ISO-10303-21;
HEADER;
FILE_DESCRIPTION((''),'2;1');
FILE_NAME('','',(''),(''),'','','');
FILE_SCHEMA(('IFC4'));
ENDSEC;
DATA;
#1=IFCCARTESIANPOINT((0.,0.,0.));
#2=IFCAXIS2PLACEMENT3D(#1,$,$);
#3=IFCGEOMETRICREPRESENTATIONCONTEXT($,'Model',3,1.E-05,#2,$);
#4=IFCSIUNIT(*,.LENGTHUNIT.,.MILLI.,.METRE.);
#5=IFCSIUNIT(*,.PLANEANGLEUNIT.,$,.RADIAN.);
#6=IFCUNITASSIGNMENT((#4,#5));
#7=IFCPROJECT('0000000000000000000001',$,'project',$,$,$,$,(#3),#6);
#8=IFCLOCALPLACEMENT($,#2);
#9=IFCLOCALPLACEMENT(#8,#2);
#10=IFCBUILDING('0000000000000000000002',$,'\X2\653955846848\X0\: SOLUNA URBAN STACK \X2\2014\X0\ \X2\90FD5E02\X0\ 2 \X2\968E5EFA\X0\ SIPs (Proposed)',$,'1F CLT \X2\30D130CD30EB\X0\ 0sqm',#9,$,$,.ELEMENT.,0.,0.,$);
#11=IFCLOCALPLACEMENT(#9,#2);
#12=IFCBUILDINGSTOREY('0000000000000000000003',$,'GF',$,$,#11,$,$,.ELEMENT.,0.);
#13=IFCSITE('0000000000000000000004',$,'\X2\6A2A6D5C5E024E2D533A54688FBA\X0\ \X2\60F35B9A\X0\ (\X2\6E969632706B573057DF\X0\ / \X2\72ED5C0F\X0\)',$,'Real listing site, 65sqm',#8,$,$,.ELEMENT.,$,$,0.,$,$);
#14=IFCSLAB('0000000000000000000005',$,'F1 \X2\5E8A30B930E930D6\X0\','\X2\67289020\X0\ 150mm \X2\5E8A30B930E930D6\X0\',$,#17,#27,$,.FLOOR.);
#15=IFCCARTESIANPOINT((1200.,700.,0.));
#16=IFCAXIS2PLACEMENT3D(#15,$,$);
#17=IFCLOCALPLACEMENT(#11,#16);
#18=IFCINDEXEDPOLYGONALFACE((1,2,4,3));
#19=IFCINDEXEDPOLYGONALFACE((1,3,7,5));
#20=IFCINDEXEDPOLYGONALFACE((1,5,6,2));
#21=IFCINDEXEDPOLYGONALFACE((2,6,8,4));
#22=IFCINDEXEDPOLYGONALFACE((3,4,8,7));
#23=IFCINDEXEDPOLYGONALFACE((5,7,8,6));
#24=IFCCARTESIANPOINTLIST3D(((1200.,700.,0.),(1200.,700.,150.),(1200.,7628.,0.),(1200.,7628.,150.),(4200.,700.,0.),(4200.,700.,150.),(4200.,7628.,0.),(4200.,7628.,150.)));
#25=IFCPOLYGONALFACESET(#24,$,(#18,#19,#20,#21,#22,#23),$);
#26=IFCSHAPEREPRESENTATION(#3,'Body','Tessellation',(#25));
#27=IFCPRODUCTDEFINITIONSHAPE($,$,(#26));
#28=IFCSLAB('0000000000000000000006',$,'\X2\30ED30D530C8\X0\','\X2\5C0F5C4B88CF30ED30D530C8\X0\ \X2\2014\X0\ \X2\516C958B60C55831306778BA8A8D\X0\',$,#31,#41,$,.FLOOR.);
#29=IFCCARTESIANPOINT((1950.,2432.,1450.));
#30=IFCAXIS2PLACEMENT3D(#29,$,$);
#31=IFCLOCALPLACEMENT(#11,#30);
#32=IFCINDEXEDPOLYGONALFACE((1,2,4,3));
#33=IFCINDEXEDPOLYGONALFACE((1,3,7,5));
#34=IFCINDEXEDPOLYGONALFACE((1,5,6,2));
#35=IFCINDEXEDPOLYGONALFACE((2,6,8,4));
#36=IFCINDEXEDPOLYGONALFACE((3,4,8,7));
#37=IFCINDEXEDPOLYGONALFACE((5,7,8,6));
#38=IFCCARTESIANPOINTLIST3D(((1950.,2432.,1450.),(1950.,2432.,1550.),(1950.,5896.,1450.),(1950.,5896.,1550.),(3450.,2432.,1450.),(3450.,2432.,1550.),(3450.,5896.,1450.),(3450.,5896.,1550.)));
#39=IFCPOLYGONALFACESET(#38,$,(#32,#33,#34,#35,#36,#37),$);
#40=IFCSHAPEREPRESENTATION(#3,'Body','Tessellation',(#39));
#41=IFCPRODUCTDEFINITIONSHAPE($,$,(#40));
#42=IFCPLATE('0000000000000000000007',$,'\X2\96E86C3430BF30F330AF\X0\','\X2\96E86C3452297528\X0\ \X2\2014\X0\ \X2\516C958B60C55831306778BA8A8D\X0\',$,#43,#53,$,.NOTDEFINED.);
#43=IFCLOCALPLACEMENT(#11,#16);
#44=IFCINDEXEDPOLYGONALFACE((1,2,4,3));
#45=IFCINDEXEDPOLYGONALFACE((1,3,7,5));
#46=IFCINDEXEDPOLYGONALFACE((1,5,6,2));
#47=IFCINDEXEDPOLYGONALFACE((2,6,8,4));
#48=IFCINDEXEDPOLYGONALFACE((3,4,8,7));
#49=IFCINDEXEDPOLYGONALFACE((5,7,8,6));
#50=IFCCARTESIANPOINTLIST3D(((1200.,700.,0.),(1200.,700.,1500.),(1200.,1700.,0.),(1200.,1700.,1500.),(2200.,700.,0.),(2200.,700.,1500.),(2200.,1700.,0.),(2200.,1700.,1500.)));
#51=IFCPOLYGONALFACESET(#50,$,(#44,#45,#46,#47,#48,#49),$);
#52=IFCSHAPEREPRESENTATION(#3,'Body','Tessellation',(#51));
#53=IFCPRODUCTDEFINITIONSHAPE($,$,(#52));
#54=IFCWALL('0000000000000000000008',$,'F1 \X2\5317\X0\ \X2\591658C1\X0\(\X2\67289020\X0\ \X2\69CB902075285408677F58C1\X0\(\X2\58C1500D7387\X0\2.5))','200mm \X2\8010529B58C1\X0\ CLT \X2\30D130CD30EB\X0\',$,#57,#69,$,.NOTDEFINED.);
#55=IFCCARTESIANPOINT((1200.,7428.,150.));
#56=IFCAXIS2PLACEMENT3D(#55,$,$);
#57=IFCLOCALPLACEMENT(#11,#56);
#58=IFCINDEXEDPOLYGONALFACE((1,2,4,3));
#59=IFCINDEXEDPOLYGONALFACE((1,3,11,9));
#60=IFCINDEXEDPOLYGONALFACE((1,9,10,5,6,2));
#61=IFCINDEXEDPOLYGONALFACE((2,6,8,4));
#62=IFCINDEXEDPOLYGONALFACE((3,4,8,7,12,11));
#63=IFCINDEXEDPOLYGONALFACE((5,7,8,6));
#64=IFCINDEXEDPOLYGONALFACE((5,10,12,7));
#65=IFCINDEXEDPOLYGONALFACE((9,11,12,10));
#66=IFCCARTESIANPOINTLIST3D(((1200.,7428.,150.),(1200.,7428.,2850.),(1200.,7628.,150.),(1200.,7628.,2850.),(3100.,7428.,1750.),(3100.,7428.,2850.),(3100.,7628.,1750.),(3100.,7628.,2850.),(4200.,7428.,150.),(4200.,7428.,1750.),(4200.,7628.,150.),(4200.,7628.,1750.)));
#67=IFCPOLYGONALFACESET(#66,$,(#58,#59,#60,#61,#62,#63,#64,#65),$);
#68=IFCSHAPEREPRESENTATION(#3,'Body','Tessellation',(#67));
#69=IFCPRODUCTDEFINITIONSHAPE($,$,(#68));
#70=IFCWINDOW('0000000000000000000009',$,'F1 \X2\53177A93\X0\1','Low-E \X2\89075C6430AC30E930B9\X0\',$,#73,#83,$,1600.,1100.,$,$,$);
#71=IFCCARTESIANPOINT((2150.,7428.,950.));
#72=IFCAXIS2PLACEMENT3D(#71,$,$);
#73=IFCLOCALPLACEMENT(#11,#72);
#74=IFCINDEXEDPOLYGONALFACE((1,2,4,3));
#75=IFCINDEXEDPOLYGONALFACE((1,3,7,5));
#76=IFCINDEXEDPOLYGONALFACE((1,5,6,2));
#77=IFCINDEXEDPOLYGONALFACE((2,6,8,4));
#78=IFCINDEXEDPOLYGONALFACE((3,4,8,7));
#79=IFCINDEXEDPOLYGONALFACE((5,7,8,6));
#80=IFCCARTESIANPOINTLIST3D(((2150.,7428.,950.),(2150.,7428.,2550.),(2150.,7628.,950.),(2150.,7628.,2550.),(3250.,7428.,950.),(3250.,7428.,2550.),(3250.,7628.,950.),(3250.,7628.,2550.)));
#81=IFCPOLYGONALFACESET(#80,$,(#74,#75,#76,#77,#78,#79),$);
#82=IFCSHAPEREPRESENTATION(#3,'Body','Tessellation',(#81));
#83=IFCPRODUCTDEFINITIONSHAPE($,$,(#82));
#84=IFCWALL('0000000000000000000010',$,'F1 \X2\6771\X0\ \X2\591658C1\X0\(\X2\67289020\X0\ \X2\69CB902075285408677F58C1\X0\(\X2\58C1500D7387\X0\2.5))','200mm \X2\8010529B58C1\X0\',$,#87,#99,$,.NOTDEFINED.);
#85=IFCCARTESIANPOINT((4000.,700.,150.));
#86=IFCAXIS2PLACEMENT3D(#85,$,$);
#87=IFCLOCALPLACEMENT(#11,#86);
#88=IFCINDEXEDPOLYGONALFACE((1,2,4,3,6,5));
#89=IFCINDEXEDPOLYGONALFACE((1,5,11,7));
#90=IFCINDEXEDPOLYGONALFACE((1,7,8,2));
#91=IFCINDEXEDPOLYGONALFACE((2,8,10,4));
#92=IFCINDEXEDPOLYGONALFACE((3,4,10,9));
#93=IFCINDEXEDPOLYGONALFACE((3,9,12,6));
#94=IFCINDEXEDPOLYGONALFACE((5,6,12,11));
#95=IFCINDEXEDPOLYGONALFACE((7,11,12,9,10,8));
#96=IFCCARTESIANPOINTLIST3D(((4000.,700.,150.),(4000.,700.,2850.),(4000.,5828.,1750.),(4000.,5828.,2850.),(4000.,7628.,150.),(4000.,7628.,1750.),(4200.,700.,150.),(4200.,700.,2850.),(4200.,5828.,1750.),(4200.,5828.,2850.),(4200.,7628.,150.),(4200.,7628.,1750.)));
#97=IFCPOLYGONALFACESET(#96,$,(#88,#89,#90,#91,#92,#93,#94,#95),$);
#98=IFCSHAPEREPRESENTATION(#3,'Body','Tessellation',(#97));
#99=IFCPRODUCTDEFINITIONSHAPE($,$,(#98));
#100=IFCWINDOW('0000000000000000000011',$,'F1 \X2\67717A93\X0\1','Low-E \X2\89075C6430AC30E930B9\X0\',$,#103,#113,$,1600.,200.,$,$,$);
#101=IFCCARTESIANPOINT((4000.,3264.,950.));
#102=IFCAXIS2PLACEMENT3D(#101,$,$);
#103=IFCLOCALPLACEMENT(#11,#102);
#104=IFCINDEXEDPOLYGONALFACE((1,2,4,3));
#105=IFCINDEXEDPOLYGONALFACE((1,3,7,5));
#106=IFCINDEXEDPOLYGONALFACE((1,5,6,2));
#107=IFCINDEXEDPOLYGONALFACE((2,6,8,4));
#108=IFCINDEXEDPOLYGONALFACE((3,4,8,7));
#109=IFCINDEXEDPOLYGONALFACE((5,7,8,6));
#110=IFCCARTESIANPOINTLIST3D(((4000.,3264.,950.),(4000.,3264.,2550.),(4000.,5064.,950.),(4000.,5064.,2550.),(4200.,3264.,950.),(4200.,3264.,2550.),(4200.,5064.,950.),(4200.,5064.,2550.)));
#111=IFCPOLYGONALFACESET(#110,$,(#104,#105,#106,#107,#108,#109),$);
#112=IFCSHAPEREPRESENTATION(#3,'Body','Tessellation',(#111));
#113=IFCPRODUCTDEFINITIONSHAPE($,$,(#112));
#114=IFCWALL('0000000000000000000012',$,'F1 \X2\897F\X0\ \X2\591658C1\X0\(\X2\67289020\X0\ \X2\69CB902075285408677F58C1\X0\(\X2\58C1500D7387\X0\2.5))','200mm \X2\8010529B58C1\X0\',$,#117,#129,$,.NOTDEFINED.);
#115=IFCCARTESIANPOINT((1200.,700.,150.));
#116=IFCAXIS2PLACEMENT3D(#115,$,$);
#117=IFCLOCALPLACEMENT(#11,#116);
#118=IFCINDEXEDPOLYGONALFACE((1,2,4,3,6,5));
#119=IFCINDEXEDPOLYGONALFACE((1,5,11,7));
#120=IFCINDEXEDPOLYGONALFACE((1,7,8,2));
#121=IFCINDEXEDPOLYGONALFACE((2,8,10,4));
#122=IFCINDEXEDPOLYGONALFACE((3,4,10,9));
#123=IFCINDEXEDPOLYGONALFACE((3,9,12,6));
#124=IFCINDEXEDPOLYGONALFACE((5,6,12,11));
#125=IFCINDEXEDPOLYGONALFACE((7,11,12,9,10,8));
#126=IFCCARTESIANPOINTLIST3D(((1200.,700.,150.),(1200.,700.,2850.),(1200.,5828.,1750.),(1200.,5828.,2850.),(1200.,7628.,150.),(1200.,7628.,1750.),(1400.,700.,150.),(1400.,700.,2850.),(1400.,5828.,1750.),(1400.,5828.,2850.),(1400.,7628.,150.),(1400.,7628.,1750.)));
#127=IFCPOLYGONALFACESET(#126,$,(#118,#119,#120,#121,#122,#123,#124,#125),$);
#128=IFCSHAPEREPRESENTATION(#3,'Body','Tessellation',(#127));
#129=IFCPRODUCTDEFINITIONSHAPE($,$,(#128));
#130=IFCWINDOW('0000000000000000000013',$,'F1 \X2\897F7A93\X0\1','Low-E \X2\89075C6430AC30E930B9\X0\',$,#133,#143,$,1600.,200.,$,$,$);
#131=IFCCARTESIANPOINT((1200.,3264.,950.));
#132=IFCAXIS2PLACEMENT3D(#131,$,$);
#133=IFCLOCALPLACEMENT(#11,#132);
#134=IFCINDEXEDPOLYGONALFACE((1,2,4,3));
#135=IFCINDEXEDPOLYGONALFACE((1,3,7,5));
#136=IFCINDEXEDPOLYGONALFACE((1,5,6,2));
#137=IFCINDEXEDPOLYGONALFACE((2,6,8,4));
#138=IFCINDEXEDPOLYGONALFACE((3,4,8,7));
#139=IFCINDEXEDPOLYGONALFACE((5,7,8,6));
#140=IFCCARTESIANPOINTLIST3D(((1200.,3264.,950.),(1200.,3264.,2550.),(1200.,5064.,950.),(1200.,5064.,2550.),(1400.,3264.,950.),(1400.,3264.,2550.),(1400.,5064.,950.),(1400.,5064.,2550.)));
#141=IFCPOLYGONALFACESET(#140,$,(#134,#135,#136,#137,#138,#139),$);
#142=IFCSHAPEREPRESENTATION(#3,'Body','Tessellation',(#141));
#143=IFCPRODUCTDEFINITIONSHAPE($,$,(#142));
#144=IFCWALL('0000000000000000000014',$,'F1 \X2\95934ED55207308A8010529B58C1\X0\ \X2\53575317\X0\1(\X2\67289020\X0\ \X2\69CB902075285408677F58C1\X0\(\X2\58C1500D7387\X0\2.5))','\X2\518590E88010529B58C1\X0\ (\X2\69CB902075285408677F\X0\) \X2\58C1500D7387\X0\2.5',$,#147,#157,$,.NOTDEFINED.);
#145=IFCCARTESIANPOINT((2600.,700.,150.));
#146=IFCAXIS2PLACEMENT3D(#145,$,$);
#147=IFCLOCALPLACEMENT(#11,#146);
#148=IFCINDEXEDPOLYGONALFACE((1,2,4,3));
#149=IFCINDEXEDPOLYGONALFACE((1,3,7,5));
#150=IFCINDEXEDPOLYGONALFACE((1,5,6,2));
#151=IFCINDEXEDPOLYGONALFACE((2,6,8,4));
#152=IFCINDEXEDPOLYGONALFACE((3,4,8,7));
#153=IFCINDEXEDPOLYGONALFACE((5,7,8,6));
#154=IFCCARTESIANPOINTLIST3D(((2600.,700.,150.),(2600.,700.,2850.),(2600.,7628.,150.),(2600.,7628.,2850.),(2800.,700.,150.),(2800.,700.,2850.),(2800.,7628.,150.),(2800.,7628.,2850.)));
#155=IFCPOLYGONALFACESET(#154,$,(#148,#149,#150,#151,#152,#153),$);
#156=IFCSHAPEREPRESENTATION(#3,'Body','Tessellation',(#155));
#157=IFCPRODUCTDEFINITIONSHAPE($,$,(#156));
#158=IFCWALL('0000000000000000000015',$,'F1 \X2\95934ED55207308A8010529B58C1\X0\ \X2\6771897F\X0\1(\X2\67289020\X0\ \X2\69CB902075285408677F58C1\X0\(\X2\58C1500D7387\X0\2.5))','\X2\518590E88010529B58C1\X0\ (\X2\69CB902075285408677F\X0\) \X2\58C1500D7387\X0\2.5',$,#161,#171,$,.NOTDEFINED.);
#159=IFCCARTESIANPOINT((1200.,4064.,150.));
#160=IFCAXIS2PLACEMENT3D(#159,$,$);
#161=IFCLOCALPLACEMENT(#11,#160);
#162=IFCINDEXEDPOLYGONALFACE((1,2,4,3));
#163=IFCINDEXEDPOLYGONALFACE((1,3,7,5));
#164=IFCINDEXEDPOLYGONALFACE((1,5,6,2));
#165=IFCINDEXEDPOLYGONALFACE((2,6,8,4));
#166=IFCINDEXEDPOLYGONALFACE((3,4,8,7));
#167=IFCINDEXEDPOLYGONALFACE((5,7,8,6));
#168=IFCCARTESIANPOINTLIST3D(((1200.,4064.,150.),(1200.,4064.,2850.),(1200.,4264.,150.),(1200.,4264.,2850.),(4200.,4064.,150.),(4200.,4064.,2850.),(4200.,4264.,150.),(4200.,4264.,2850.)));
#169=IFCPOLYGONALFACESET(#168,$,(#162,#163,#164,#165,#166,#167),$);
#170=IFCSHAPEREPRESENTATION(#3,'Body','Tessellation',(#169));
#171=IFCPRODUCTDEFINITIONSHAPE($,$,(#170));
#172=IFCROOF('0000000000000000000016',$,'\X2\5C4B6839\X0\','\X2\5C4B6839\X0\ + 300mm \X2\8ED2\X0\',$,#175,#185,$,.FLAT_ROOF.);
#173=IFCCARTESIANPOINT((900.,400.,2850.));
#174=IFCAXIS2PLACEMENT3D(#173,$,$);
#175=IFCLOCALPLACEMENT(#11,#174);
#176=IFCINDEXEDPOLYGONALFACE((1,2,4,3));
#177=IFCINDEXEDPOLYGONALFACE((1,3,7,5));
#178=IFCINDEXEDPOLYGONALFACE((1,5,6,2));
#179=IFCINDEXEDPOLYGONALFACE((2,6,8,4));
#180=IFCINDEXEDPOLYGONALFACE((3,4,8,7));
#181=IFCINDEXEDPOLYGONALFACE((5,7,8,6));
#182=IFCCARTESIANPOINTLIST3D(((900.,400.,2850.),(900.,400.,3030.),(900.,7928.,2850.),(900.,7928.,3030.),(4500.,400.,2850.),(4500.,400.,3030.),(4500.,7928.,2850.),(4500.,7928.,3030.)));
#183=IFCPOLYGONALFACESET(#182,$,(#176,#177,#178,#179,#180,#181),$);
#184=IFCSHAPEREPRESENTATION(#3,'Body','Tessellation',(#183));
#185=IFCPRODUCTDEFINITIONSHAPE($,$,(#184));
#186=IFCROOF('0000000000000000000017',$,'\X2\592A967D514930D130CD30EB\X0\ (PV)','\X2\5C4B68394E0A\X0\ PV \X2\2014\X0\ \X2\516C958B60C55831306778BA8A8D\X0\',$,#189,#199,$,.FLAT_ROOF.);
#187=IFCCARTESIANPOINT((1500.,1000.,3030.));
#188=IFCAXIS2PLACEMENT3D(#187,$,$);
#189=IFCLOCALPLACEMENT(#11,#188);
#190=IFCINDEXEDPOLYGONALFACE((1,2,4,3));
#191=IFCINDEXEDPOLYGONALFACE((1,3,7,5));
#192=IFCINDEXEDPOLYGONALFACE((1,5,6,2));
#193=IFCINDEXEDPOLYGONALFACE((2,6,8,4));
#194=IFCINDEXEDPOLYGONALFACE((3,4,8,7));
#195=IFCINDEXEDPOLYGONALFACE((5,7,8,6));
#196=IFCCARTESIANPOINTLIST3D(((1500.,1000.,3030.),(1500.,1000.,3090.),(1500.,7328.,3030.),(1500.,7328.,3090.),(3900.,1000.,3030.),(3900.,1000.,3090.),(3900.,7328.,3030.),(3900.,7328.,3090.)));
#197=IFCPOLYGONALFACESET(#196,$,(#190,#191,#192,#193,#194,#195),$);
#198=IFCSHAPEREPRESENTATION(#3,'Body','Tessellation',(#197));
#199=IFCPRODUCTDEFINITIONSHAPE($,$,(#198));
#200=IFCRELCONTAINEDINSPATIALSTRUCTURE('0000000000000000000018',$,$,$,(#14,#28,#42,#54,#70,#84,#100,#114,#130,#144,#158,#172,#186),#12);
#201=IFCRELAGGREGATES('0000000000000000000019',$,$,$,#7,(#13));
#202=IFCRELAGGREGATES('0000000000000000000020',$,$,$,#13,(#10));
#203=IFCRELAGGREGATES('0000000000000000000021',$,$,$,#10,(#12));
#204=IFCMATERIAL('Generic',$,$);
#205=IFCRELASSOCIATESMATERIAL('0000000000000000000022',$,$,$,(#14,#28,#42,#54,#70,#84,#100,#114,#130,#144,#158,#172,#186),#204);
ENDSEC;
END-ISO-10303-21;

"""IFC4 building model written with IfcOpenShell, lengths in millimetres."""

from ifc_helpers import new_model, si_unit, frame, frame_2d, origin, place, context, project, spatial, rectangle, extrude, material, element, fill, save


model = new_model("IFC4")

# Units and contexts
model_context = context("Model", 3, precision=1e-05, world=origin())
ifc_project = project(units=[si_unit("LENGTHUNIT", "METRE", prefix="MILLI"), si_unit("PLANEANGLEUNIT", "RADIAN")], contexts=[model_context])

# Site, building, storey
site_placement = place(None, origin())
site = spatial("IfcSite", under=ifc_project, at=site_placement, Name="横浜市中区周辺 想定 (準防火地域 / 狭小)", ObjectType="Real listing site, 65sqm", CompositionType="ELEMENT", RefElevation=0.0)
building_placement = place(site_placement, origin())
building = spatial("IfcBuilding", under=site, at=building_placement, Name="改善案: SOLUNA URBAN STACK — 都市 2 階建 SIPs (Proposed)", ObjectType="1F CLT パネル 0sqm", CompositionType="ELEMENT", ElevationOfRefHeight=0.0, ElevationOfTerrain=0.0)
storey_placement = place(building_placement, origin())
storey = spatial("IfcBuildingStorey", under=building, at=storey_placement, Name="GF", CompositionType="ELEMENT", Elevation=0.0)

# Slabs
ifc_material_1 = material(Name="Generic")
slab_1_placement = place(storey_placement, frame((1200.0, 700.0, 0.0)))
element("IfcSlab", 1, at=slab_1_placement, inside=storey, material=ifc_material_1, Name="F1 床スラブ", Description="木造 150mm 床スラブ", PredefinedType="FLOOR", context=model_context, shape_type="SweptSolid", body=[
    extrude(rectangle(XDim=3000.0, YDim=6928.0, at=frame_2d((1500.0, 3464.0))), frame((1200.0, 700.0, 0.0)), (0.0, 0.0, 1.0), 150.0),
])
slab_2_placement = place(storey_placement, frame((1950.0, 2432.0, 1450.0)))
element("IfcSlab", 2, at=slab_2_placement, inside=storey, material=ifc_material_1, Name="ロフト", Description="小屋裏ロフト — 公開情報で確認", PredefinedType="FLOOR", context=model_context, shape_type="SweptSolid", body=[
    extrude(rectangle(XDim=1500.0, YDim=3464.0, at=frame_2d((750.0, 1732.0))), frame((1950.0, 2432.0, 1450.0)), (0.0, 0.0, 1.0), 100.0),
])

# Plate
plate_placement = place(storey_placement, frame((1200.0, 700.0, 0.0)))
element("IfcPlate", 3, at=plate_placement, inside=storey, material=ifc_material_1, Name="雨水タンク", Description="雨水利用 — 公開情報で確認", PredefinedType="NOTDEFINED", context=model_context, shape_type="SweptSolid", body=[
    extrude(rectangle(XDim=1000.0, YDim=1000.0, at=frame_2d((500.0, 500.0))), frame((1200.0, 700.0, 0.0)), (0.0, 0.0, 1.0), 1500.0),
])

# Wall, opening, window
wall_1_placement = place(storey_placement, frame((1200.0, 7428.0, 150.0)))
wall_1 = element("IfcWall", 4, at=wall_1_placement, inside=storey, material=ifc_material_1, Name="F1 北 外壁(木造 構造用合板壁(壁倍率2.5))", Description="200mm 耐力壁 CLT パネル", PredefinedType="NOTDEFINED", context=model_context, shape_type="SweptSolid", body=[
    extrude(rectangle(XDim=3000.0, YDim=200.0, at=frame_2d((1500.0, 100.0))), frame((1200.0, 7428.0, 150.0)), (0.0, 0.0, 1.0), 2700.0),
])
opening_1_placement = place(storey_placement, frame((2150.0, 7428.0, 950.0)))
opening_1 = element("IfcOpeningElement", 5, at=opening_1_placement, cuts=wall_1, PredefinedType="NOTDEFINED", context=model_context, shape_type="SweptSolid", body=[
    extrude(rectangle(XDim=1100.0, YDim=200.0, at=frame_2d((550.0, 100.0))), frame((2150.0, 7428.0, 950.0)), (0.0, 0.0, 1.0), 1600.0),
])
window_1_placement = place(storey_placement, frame((2150.0, 7428.0, 950.0)))
window_1 = element("IfcWindow", 6, at=window_1_placement, inside=storey, material=ifc_material_1, Name="F1 北窓1", Description="Low-E 複層ガラス", OverallHeight=1600.0, OverallWidth=1100.0, context=model_context, shape_type="SweptSolid", body=[
    extrude(rectangle(XDim=1100.0, YDim=200.0, at=frame_2d((550.0, 100.0))), frame((2150.0, 7428.0, 950.0)), (0.0, 0.0, 1.0), 1600.0),
])
fill(opening_1, window_1)

# Walls, openings, windows
wall_2_placement = place(storey_placement, frame((4000.0, 700.0, 150.0)))
wall_2 = element("IfcWall", 7, at=wall_2_placement, inside=storey, material=ifc_material_1, Name="F1 東 外壁(木造 構造用合板壁(壁倍率2.5))", Description="200mm 耐力壁", PredefinedType="NOTDEFINED", context=model_context, shape_type="SweptSolid", body=[
    extrude(rectangle(XDim=200.0, YDim=6928.0, at=frame_2d((100.0, 3464.0))), frame((4000.0, 700.0, 150.0)), (0.0, 0.0, 1.0), 2700.0),
])
opening_2_placement = place(storey_placement, frame((4000.0, 3264.0, 950.0)))
opening_2 = element("IfcOpeningElement", 8, at=opening_2_placement, cuts=wall_2, PredefinedType="NOTDEFINED", context=model_context, shape_type="SweptSolid", body=[
    extrude(rectangle(XDim=200.0, YDim=1800.0, at=frame_2d((100.0, 900.0))), frame((4000.0, 3264.0, 950.0)), (0.0, 0.0, 1.0), 1600.0),
])
window_2_placement = place(storey_placement, frame((4000.0, 3264.0, 950.0)))
window_2 = element("IfcWindow", 9, at=window_2_placement, inside=storey, material=ifc_material_1, Name="F1 東窓1", Description="Low-E 複層ガラス", OverallHeight=1600.0, OverallWidth=200.0, context=model_context, shape_type="SweptSolid", body=[
    extrude(rectangle(XDim=200.0, YDim=1800.0, at=frame_2d((100.0, 900.0))), frame((4000.0, 3264.0, 950.0)), (0.0, 0.0, 1.0), 1600.0),
])
fill(opening_2, window_2)
wall_3_placement = place(storey_placement, frame((1200.0, 700.0, 150.0)))
wall_3 = element("IfcWall", 10, at=wall_3_placement, inside=storey, material=ifc_material_1, Name="F1 西 外壁(木造 構造用合板壁(壁倍率2.5))", Description="200mm 耐力壁", PredefinedType="NOTDEFINED", context=model_context, shape_type="SweptSolid", body=[
    extrude(rectangle(XDim=200.0, YDim=6928.0, at=frame_2d((100.0, 3464.0))), frame((1200.0, 700.0, 150.0)), (0.0, 0.0, 1.0), 2700.0),
])
opening_3_placement = place(storey_placement, frame((1200.0, 3264.0, 950.0)))
opening_3 = element("IfcOpeningElement", 11, at=opening_3_placement, cuts=wall_3, PredefinedType="NOTDEFINED", context=model_context, shape_type="SweptSolid", body=[
    extrude(rectangle(XDim=200.0, YDim=1800.0, at=frame_2d((100.0, 900.0))), frame((1200.0, 3264.0, 950.0)), (0.0, 0.0, 1.0), 1600.0),
])
window_3_placement = place(storey_placement, frame((1200.0, 3264.0, 950.0)))
window_3 = element("IfcWindow", 12, at=window_3_placement, inside=storey, material=ifc_material_1, Name="F1 西窓1", Description="Low-E 複層ガラス", OverallHeight=1600.0, OverallWidth=200.0, context=model_context, shape_type="SweptSolid", body=[
    extrude(rectangle(XDim=200.0, YDim=1800.0, at=frame_2d((100.0, 900.0))), frame((1200.0, 3264.0, 950.0)), (0.0, 0.0, 1.0), 1600.0),
])
fill(opening_3, window_3)

# Walls
wall_4_placement = place(storey_placement, frame((2600.0, 700.0, 150.0)))
element("IfcWall", 13, at=wall_4_placement, inside=storey, material=ifc_material_1, Name="F1 間仕切り耐力壁 南北1(木造 構造用合板壁(壁倍率2.5))", Description="内部耐力壁 (構造用合板) 壁倍率2.5", PredefinedType="NOTDEFINED", context=model_context, shape_type="SweptSolid", body=[
    extrude(rectangle(XDim=200.0, YDim=6928.0, at=frame_2d((100.0, 3464.0))), frame((2600.0, 700.0, 150.0)), (0.0, 0.0, 1.0), 2700.0),
])
wall_5_placement = place(storey_placement, frame((1200.0, 4064.0, 150.0)))
element("IfcWall", 14, at=wall_5_placement, inside=storey, material=ifc_material_1, Name="F1 間仕切り耐力壁 東西1(木造 構造用合板壁(壁倍率2.5))", Description="内部耐力壁 (構造用合板) 壁倍率2.5", PredefinedType="NOTDEFINED", context=model_context, shape_type="SweptSolid", body=[
    extrude(rectangle(XDim=3000.0, YDim=200.0, at=frame_2d((1500.0, 100.0))), frame((1200.0, 4064.0, 150.0)), (0.0, 0.0, 1.0), 2700.0),
])

# Roofs
roof_1_placement = place(storey_placement, frame((900.0, 400.0, 2850.0)))
element("IfcRoof", 15, at=roof_1_placement, inside=storey, material=ifc_material_1, Name="屋根", Description="屋根 + 300mm 軒", PredefinedType="FLAT_ROOF", context=model_context, shape_type="SweptSolid", body=[
    extrude(rectangle(XDim=3600.0, YDim=7528.0, at=frame_2d((1800.0, 3764.0))), frame((900.0, 400.0, 2850.0)), (0.0, 0.0, 1.0), 180.0),
])
roof_2_placement = place(storey_placement, frame((1500.0, 1000.0, 3030.0)))
element("IfcRoof", 16, at=roof_2_placement, inside=storey, material=ifc_material_1, Name="太陽光パネル (PV)", Description="屋根上 PV — 公開情報で確認", PredefinedType="FLAT_ROOF", context=model_context, shape_type="SweptSolid", body=[
    extrude(rectangle(XDim=2400.0, YDim=6328.0, at=frame_2d((1200.0, 3164.0))), frame((1500.0, 1000.0, 3030.0)), (0.0, 0.0, 1.0), 60.0),
])

save(model, "model.ifc")
